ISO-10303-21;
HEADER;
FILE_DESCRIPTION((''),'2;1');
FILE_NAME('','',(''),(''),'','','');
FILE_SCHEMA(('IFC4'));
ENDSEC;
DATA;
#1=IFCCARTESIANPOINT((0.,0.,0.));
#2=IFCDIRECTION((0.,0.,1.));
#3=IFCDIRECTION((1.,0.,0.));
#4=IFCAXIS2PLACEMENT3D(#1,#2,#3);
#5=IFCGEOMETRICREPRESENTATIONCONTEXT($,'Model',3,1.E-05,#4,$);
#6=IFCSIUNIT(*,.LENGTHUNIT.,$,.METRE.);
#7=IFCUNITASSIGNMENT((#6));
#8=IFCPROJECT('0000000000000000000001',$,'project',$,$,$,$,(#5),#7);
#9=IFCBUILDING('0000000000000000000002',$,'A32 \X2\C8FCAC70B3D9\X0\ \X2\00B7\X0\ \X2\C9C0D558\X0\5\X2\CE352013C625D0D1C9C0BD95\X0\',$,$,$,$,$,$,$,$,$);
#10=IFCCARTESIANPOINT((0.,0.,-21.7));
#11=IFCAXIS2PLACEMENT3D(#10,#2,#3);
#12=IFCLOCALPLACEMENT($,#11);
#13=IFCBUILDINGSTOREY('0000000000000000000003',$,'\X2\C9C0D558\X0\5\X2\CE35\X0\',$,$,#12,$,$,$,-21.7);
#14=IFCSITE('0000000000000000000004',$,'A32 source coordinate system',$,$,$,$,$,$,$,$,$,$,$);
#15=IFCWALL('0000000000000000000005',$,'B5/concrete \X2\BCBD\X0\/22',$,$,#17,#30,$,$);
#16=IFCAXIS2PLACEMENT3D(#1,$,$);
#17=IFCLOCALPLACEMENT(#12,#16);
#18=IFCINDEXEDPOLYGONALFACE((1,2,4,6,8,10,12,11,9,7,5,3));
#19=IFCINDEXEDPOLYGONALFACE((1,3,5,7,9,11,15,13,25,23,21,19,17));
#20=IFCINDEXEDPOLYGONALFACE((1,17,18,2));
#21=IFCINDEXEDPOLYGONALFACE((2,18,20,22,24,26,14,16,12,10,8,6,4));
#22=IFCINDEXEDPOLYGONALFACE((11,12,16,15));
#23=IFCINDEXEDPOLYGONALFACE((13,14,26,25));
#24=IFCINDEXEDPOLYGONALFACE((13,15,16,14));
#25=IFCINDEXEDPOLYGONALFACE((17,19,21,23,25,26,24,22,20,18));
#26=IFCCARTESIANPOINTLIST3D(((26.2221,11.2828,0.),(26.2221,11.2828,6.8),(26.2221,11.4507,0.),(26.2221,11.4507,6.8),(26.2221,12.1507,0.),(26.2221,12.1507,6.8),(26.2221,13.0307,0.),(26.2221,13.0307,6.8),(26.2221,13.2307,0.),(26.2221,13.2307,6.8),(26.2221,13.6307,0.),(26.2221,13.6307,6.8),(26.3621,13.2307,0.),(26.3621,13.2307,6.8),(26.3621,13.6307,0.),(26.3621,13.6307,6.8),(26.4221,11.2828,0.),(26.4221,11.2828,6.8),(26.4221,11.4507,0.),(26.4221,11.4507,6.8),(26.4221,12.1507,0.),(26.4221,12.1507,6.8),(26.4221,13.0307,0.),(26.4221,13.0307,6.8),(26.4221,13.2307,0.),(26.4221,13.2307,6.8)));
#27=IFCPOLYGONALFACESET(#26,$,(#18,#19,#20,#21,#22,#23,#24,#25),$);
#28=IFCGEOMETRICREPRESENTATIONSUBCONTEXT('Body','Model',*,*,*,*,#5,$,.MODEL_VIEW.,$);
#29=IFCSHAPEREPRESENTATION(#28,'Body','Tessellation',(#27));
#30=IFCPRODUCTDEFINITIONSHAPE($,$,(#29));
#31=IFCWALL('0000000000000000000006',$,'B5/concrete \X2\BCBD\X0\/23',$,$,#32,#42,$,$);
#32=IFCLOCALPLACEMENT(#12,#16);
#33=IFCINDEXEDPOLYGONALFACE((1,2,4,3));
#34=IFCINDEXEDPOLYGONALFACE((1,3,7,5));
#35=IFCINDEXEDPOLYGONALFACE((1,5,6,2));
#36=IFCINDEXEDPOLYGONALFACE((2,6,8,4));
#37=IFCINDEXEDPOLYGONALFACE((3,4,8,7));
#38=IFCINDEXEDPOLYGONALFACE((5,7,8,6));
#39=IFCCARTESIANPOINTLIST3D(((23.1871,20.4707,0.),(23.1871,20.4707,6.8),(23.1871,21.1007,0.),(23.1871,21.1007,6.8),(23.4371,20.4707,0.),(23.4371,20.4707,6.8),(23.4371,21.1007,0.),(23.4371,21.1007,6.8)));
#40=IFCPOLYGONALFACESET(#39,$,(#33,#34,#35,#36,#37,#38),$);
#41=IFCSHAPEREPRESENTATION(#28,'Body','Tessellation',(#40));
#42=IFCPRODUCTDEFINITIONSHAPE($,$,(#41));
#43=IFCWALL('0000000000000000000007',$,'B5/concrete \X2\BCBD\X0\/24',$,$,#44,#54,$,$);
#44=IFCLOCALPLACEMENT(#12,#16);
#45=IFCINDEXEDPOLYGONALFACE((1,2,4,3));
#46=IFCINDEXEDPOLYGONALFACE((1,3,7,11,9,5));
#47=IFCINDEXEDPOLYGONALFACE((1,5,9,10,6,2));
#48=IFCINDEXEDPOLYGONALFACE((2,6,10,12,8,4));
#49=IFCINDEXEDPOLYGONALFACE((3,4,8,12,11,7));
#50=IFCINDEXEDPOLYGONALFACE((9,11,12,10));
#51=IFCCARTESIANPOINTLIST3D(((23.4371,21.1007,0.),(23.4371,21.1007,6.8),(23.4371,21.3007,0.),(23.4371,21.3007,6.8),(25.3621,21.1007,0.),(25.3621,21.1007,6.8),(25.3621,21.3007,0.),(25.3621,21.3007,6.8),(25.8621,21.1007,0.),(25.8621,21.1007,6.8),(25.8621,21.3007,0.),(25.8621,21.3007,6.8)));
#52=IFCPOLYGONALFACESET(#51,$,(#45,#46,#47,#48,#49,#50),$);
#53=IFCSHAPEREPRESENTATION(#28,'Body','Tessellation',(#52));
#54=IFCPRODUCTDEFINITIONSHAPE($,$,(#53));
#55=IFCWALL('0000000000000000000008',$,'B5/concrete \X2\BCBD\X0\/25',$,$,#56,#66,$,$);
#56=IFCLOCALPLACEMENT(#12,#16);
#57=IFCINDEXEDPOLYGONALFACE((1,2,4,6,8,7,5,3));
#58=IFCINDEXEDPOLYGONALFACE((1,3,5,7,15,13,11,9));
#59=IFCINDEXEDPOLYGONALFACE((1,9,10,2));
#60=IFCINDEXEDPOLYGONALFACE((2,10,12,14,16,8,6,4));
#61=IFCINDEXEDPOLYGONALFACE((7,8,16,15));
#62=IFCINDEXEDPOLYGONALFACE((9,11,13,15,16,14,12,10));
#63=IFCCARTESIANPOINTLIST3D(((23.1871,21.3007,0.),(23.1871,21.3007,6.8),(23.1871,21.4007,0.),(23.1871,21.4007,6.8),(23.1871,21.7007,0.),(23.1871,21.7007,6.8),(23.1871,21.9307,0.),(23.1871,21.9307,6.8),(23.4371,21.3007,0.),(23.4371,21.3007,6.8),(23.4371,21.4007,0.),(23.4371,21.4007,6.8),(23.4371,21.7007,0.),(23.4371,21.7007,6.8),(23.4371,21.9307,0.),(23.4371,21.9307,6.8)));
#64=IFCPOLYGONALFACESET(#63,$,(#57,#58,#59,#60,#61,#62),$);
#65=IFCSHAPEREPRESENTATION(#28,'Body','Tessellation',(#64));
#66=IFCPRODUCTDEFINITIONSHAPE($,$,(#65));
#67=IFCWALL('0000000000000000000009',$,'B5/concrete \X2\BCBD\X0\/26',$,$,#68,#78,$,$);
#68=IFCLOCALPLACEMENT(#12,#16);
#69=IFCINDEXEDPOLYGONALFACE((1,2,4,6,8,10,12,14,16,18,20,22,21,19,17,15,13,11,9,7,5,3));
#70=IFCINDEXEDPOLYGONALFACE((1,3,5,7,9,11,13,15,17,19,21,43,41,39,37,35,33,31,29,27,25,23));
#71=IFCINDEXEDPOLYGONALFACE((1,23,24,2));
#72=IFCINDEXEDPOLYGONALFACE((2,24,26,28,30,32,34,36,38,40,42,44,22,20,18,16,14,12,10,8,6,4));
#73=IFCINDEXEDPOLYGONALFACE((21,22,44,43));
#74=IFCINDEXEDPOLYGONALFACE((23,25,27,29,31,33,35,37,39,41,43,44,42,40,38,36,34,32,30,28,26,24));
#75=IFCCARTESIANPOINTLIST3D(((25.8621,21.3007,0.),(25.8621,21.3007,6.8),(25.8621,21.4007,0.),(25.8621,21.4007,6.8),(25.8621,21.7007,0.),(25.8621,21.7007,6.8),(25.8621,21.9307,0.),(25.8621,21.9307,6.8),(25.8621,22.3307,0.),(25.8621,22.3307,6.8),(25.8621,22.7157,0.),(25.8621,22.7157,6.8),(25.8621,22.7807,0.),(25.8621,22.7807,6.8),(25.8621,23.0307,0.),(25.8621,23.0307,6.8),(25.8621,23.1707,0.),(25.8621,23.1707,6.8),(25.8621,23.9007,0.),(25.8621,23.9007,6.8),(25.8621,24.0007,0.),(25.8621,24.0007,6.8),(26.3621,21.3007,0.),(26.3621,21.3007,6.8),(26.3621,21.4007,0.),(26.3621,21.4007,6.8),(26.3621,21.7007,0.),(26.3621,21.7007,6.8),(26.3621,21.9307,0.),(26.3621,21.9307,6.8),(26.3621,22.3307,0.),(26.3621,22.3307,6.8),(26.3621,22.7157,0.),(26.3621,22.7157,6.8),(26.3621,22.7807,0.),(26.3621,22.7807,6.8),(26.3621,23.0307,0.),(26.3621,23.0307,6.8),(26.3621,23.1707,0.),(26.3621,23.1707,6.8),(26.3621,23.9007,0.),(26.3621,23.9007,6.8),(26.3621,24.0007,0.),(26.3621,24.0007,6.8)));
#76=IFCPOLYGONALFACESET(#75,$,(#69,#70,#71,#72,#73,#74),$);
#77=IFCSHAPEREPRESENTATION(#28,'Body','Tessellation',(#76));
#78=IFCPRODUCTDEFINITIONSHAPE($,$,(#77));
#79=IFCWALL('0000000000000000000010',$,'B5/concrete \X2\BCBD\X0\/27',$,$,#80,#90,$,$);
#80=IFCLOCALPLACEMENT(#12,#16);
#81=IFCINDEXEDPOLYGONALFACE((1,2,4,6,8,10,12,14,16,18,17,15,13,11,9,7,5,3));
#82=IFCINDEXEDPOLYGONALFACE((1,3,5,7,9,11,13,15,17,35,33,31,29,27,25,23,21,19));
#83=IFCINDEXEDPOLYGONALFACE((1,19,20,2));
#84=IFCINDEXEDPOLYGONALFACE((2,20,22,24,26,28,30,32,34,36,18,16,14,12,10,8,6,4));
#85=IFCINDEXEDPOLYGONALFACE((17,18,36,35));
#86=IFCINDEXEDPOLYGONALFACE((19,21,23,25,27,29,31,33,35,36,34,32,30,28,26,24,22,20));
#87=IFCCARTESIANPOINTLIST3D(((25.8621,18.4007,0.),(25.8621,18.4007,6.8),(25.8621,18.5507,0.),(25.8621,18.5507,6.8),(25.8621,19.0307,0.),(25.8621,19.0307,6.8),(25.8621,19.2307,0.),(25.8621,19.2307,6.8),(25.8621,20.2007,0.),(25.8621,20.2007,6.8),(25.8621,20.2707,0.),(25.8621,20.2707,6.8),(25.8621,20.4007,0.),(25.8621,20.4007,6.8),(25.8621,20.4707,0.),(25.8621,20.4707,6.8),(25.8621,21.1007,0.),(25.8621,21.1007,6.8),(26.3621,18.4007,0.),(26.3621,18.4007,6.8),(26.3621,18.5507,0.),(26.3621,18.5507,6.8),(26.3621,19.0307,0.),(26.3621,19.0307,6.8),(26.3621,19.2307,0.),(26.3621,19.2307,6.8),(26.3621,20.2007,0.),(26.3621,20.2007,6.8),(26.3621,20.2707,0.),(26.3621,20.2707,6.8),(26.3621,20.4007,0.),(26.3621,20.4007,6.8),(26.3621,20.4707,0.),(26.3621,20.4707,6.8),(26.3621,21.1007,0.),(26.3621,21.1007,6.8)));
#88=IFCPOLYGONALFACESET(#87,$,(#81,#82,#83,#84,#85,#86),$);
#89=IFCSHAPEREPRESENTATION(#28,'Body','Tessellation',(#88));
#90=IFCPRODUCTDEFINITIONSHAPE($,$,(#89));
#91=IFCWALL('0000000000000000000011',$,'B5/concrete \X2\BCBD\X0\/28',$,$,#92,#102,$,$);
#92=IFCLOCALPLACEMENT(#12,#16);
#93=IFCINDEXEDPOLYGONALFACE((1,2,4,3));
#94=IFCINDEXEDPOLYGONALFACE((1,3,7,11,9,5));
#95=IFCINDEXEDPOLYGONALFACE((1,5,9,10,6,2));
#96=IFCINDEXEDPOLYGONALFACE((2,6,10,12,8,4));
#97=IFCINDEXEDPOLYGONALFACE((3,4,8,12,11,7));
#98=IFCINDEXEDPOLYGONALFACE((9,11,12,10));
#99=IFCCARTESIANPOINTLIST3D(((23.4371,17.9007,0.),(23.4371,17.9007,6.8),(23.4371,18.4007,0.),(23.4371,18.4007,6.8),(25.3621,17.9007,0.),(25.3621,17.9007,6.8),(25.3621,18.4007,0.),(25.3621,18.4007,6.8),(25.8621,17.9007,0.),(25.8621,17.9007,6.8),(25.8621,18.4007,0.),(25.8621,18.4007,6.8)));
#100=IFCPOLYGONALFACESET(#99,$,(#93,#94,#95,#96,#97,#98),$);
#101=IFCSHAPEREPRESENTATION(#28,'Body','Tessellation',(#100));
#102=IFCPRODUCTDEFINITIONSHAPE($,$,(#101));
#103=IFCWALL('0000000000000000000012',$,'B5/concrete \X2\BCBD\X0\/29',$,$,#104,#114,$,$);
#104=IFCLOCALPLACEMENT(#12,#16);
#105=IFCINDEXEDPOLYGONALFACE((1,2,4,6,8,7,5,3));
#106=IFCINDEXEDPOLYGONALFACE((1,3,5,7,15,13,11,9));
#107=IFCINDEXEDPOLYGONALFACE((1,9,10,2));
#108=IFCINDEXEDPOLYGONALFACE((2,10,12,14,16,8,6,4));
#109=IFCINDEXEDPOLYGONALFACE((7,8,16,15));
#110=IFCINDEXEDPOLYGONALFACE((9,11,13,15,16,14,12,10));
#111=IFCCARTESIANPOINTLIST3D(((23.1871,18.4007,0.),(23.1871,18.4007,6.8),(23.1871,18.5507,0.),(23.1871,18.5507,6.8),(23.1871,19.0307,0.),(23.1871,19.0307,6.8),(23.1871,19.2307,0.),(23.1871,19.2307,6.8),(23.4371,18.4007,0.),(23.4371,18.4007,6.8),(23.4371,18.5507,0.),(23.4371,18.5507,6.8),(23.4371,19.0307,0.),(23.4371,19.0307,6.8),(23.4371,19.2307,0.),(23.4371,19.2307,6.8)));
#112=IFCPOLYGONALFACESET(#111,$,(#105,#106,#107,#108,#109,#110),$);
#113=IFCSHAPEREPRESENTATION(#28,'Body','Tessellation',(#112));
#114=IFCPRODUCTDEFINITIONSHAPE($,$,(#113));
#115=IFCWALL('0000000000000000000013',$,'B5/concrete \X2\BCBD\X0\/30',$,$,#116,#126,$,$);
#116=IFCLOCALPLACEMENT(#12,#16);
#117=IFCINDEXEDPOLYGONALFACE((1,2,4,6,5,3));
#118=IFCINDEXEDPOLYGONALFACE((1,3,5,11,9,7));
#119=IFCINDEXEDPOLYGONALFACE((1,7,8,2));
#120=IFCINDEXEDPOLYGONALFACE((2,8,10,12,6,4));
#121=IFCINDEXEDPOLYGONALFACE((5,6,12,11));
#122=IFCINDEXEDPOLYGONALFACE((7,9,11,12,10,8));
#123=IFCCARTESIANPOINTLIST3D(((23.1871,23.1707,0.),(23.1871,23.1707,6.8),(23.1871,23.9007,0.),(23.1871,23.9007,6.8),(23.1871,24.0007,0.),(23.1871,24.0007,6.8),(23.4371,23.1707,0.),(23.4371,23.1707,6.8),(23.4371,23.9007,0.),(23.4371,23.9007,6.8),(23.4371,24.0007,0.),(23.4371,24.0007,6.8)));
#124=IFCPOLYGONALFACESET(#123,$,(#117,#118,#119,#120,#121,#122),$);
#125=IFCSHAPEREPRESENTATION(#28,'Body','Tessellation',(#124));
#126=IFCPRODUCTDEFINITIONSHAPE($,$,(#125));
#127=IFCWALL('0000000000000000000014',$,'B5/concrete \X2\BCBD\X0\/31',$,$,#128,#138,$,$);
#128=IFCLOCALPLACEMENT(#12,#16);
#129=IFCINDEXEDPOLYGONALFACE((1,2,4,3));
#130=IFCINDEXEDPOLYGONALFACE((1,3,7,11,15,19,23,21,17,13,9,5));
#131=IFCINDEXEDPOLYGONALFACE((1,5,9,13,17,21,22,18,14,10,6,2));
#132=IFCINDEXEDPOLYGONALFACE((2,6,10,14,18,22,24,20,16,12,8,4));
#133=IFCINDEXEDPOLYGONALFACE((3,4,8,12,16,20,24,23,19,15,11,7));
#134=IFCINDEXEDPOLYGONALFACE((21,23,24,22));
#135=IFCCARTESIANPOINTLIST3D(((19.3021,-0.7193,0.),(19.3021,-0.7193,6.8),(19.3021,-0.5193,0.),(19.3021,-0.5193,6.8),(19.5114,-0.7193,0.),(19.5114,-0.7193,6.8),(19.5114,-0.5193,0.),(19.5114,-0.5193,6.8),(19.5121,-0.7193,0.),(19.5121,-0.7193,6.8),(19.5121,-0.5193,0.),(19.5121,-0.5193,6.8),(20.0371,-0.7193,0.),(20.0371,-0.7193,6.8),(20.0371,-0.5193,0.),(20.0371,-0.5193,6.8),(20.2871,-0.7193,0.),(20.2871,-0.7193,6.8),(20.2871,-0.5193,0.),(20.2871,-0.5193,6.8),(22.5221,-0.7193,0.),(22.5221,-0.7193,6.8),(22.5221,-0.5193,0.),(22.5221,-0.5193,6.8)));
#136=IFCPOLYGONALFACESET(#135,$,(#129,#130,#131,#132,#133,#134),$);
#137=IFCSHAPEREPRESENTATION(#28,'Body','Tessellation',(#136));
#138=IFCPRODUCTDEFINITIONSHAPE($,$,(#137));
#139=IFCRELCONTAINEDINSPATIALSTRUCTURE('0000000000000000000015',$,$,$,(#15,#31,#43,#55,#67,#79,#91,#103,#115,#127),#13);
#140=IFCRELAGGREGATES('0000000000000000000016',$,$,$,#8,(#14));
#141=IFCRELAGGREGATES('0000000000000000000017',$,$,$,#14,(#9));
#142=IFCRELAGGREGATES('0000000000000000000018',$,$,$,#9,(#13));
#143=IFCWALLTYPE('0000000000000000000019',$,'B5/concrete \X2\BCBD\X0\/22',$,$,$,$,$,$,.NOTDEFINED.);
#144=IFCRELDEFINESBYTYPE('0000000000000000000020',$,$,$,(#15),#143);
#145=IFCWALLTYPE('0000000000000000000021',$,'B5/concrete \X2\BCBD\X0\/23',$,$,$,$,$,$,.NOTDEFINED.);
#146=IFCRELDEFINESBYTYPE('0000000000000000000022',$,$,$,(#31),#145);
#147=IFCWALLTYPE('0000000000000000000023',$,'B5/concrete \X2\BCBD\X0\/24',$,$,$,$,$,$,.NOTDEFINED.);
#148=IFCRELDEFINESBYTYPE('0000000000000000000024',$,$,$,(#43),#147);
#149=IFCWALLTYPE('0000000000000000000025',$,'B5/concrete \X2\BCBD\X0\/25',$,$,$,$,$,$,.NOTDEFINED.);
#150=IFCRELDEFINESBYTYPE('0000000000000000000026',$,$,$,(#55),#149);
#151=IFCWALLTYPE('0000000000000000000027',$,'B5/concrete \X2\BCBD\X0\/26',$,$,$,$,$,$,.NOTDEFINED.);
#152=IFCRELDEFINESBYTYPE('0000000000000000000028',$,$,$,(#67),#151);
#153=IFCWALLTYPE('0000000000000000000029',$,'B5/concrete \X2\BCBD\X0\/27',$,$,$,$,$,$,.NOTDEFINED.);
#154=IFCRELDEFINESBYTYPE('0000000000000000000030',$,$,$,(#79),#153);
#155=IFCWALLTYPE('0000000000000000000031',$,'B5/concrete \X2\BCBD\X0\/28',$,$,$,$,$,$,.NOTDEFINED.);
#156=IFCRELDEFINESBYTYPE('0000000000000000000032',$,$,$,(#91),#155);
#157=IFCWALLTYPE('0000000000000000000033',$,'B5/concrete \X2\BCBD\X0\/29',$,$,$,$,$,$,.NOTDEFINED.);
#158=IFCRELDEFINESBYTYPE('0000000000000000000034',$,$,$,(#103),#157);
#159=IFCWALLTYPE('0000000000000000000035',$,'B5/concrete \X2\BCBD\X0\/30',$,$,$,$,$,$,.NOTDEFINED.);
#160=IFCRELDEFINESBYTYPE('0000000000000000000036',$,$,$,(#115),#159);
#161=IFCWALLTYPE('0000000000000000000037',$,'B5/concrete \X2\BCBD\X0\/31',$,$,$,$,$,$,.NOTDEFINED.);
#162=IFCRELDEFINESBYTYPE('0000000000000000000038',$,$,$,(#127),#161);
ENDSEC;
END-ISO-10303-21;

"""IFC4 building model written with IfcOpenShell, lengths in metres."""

from ifc_helpers import new_model, si_unit, frame, origin, origin_with_axes, place, context, subcontext, project, spatial, polyline, outline, extrude, source, transform, mapped, type_object, type_shapes, element, save


model = new_model("IFC4")

# Units and contexts
model_context = context("Model", 3, precision=1e-05, world=origin_with_axes())
body_context = subcontext(model_context, "Body", "Model", "MODEL_VIEW")
ifc_project = project(units=[si_unit("LENGTHUNIT", "METRE")], contexts=[model_context])

# Site, building, storey
site = spatial("IfcSite", under=ifc_project, Name="A32 source coordinate system")
building = spatial("IfcBuilding", under=site, Name="A32 주거동 · 지하5층–옥탑지붕")
storey_placement = place(None, frame((0.0, 0.0, -21.7), z_axis=(0.0, 0.0, 1.0), x_axis=(1.0, 0.0, 0.0)))
storey = spatial("IfcBuildingStorey", under=building, at=storey_placement, Name="지하5층", Elevation=-21.7)

# Walls
wall_type_1 = type_object("IfcWallType", Name="B5/concrete 벽/22", PredefinedType="NOTDEFINED")
shared_shape_1 = source(origin(), body_context, "Body", "SweptSolid", [
    extrude(outline(polyline([(26.3621, 13.2307), (26.4221, 13.2307), (26.4221, 13.0307), (26.4221, 12.1507), (26.4221, 11.4507), (26.4221, 11.2828), (26.2221, 11.2828), (26.2221, 11.4507), (26.2221, 12.1507), (26.2221, 13.0307), (26.2221, 13.2307), (26.2221, 13.6307), (26.3621, 13.6307), (26.3621, 13.2307)])), origin(), (0.0, 0.0, 1.0), 6.8),
])
type_shapes(wall_type_1, [shared_shape_1])
wall_1_placement = place(storey_placement, origin_with_axes())
element("IfcWall", 1, at=wall_1_placement, inside=storey, type_object=wall_type_1, Name="B5/concrete 벽/22", context=body_context, shape_type="MappedRepresentation", body=[
    mapped(shared_shape_1, transform((0.0, 0.0, 0.0), scale=1.0)),
])
wall_type_2 = type_object("IfcWallType", Name="B5/concrete 벽/23", PredefinedType="NOTDEFINED")
shared_shape_2 = source(origin(), body_context, "Body", "SweptSolid", [
    extrude(outline(polyline([(23.4371, 20.4707), (23.1871, 20.4707), (23.1871, 21.1007), (23.4371, 21.1007), (23.4371, 20.4707)])), origin(), (0.0, 0.0, 1.0), 6.8),
])
type_shapes(wall_type_2, [shared_shape_2])
wall_2_placement = place(storey_placement, origin_with_axes())
element("IfcWall", 2, at=wall_2_placement, inside=storey, type_object=wall_type_2, Name="B5/concrete 벽/23", context=body_context, shape_type="MappedRepresentation", body=[
    mapped(shared_shape_2, transform((0.0, 0.0, 0.0), scale=1.0)),
])
wall_type_3 = type_object("IfcWallType", Name="B5/concrete 벽/24", PredefinedType="NOTDEFINED")
shared_shape_3 = source(origin(), body_context, "Body", "SweptSolid", [
    extrude(outline(polyline([(25.8621, 21.3007), (25.8621, 21.1007), (25.3621, 21.1007), (23.4371, 21.1007), (23.4371, 21.3007), (25.3621, 21.3007), (25.8621, 21.3007)])), origin(), (0.0, 0.0, 1.0), 6.8),
])
type_shapes(wall_type_3, [shared_shape_3])
wall_3_placement = place(storey_placement, origin_with_axes())
element("IfcWall", 3, at=wall_3_placement, inside=storey, type_object=wall_type_3, Name="B5/concrete 벽/24", context=body_context, shape_type="MappedRepresentation", body=[
    mapped(shared_shape_3, transform((0.0, 0.0, 0.0), scale=1.0)),
])
wall_type_4 = type_object("IfcWallType", Name="B5/concrete 벽/25", PredefinedType="NOTDEFINED")
shared_shape_4 = source(origin(), body_context, "Body", "SweptSolid", [
    extrude(outline(polyline([(23.1871, 21.7007), (23.1871, 21.9307), (23.4371, 21.9307), (23.4371, 21.7007), (23.4371, 21.4007), (23.4371, 21.3007), (23.1871, 21.3007), (23.1871, 21.4007), (23.1871, 21.7007)])), origin(), (0.0, 0.0, 1.0), 6.8),
])
type_shapes(wall_type_4, [shared_shape_4])
wall_4_placement = place(storey_placement, origin_with_axes())
element("IfcWall", 4, at=wall_4_placement, inside=storey, type_object=wall_type_4, Name="B5/concrete 벽/25", context=body_context, shape_type="MappedRepresentation", body=[
    mapped(shared_shape_4, transform((0.0, 0.0, 0.0), scale=1.0)),
])
wall_type_5 = type_object("IfcWallType", Name="B5/concrete 벽/26", PredefinedType="NOTDEFINED")
shared_shape_5 = source(origin(), body_context, "Body", "SweptSolid", [
    extrude(outline(polyline([(25.8621, 21.9307), (25.8621, 22.3307), (25.8621, 22.7157), (25.8621, 22.7807), (25.8621, 23.0307), (25.8621, 23.1707), (25.8621, 23.9007), (25.8621, 24.0007), (26.3621, 24.0007), (26.3621, 23.9007), (26.3621, 23.1707), (26.3621, 23.0307), (26.3621, 22.7807), (26.3621, 22.7157), (26.3621, 22.3307), (26.3621, 21.9307), (26.3621, 21.7007), (26.3621, 21.4007), (26.3621, 21.3007), (25.8621, 21.3007), (25.8621, 21.4007), (25.8621, 21.7007), (25.8621, 21.9307)])), origin(), (0.0, 0.0, 1.0), 6.8),
])
type_shapes(wall_type_5, [shared_shape_5])
wall_5_placement = place(storey_placement, origin_with_axes())
element("IfcWall", 5, at=wall_5_placement, inside=storey, type_object=wall_type_5, Name="B5/concrete 벽/26", context=body_context, shape_type="MappedRepresentation", body=[
    mapped(shared_shape_5, transform((0.0, 0.0, 0.0), scale=1.0)),
])
wall_type_6 = type_object("IfcWallType", Name="B5/concrete 벽/27", PredefinedType="NOTDEFINED")
shared_shape_6 = source(origin(), body_context, "Body", "SweptSolid", [
    extrude(outline(polyline([(26.3621, 20.4007), (26.3621, 20.2707), (26.3621, 20.2007), (26.3621, 19.2307), (26.3621, 19.0307), (26.3621, 18.5507), (26.3621, 18.4007), (25.8621, 18.4007), (25.8621, 18.5507), (25.8621, 19.0307), (25.8621, 19.2307), (25.8621, 20.2007), (25.8621, 20.2707), (25.8621, 20.4007), (25.8621, 20.4707), (25.8621, 21.1007), (26.3621, 21.1007), (26.3621, 20.4707), (26.3621, 20.4007)])), origin(), (0.0, 0.0, 1.0), 6.8),
])
type_shapes(wall_type_6, [shared_shape_6])
wall_6_placement = place(storey_placement, origin_with_axes())
element("IfcWall", 6, at=wall_6_placement, inside=storey, type_object=wall_type_6, Name="B5/concrete 벽/27", context=body_context, shape_type="MappedRepresentation", body=[
    mapped(shared_shape_6, transform((0.0, 0.0, 0.0), scale=1.0)),
])
wall_type_7 = type_object("IfcWallType", Name="B5/concrete 벽/28", PredefinedType="NOTDEFINED")
shared_shape_7 = source(origin(), body_context, "Body", "SweptSolid", [
    extrude(outline(polyline([(23.4371, 17.9007), (23.4371, 18.4007), (25.3621, 18.4007), (25.8621, 18.4007), (25.8621, 17.9007), (25.3621, 17.9007), (23.4371, 17.9007)])), origin(), (0.0, 0.0, 1.0), 6.8),
])
type_shapes(wall_type_7, [shared_shape_7])
wall_7_placement = place(storey_placement, origin_with_axes())
element("IfcWall", 7, at=wall_7_placement, inside=storey, type_object=wall_type_7, Name="B5/concrete 벽/28", context=body_context, shape_type="MappedRepresentation", body=[
    mapped(shared_shape_7, transform((0.0, 0.0, 0.0), scale=1.0)),
])
wall_type_8 = type_object("IfcWallType", Name="B5/concrete 벽/29", PredefinedType="NOTDEFINED")
shared_shape_8 = source(origin(), body_context, "Body", "SweptSolid", [
    extrude(outline(polyline([(23.1871, 19.0307), (23.1871, 19.2307), (23.4371, 19.2307), (23.4371, 19.0307), (23.4371, 18.5507), (23.4371, 18.4007), (23.1871, 18.4007), (23.1871, 18.5507), (23.1871, 19.0307)])), origin(), (0.0, 0.0, 1.0), 6.8),
])
type_shapes(wall_type_8, [shared_shape_8])
wall_8_placement = place(storey_placement, origin_with_axes())
element("IfcWall", 8, at=wall_8_placement, inside=storey, type_object=wall_type_8, Name="B5/concrete 벽/29", context=body_context, shape_type="MappedRepresentation", body=[
    mapped(shared_shape_8, transform((0.0, 0.0, 0.0), scale=1.0)),
])
wall_type_9 = type_object("IfcWallType", Name="B5/concrete 벽/30", PredefinedType="NOTDEFINED")
shared_shape_9 = source(origin(), body_context, "Body", "SweptSolid", [
    extrude(outline(polyline([(23.1871, 24.0007), (23.4371, 24.0007), (23.4371, 23.9007), (23.4371, 23.1707), (23.1871, 23.1707), (23.1871, 23.9007), (23.1871, 24.0007)])), origin(), (0.0, 0.0, 1.0), 6.8),
])
type_shapes(wall_type_9, [shared_shape_9])
wall_9_placement = place(storey_placement, origin_with_axes())
element("IfcWall", 9, at=wall_9_placement, inside=storey, type_object=wall_type_9, Name="B5/concrete 벽/30", context=body_context, shape_type="MappedRepresentation", body=[
    mapped(shared_shape_9, transform((0.0, 0.0, 0.0), scale=1.0)),
])
wall_type_10 = type_object("IfcWallType", Name="B5/concrete 벽/31", PredefinedType="NOTDEFINED")
shared_shape_10 = source(origin(), body_context, "Body", "SweptSolid", [
    extrude(outline(polyline([(19.3021, -0.5193), (19.5114, -0.5193), (19.5121, -0.5193), (20.0371, -0.5193), (20.2871, -0.5193), (22.5221, -0.5193), (22.5221, -0.7193), (20.2871, -0.7193), (20.0371, -0.7193), (19.5121, -0.7193), (19.5114, -0.7193), (19.3021, -0.7193), (19.3021, -0.5193)])), origin(), (0.0, 0.0, 1.0), 6.8),
])
type_shapes(wall_type_10, [shared_shape_10])
wall_10_placement = place(storey_placement, origin_with_axes())
element("IfcWall", 10, at=wall_10_placement, inside=storey, type_object=wall_type_10, Name="B5/concrete 벽/31", context=body_context, shape_type="MappedRepresentation", body=[
    mapped(shared_shape_10, transform((0.0, 0.0, 0.0), scale=1.0)),
])

save(model, "model.ifc")
